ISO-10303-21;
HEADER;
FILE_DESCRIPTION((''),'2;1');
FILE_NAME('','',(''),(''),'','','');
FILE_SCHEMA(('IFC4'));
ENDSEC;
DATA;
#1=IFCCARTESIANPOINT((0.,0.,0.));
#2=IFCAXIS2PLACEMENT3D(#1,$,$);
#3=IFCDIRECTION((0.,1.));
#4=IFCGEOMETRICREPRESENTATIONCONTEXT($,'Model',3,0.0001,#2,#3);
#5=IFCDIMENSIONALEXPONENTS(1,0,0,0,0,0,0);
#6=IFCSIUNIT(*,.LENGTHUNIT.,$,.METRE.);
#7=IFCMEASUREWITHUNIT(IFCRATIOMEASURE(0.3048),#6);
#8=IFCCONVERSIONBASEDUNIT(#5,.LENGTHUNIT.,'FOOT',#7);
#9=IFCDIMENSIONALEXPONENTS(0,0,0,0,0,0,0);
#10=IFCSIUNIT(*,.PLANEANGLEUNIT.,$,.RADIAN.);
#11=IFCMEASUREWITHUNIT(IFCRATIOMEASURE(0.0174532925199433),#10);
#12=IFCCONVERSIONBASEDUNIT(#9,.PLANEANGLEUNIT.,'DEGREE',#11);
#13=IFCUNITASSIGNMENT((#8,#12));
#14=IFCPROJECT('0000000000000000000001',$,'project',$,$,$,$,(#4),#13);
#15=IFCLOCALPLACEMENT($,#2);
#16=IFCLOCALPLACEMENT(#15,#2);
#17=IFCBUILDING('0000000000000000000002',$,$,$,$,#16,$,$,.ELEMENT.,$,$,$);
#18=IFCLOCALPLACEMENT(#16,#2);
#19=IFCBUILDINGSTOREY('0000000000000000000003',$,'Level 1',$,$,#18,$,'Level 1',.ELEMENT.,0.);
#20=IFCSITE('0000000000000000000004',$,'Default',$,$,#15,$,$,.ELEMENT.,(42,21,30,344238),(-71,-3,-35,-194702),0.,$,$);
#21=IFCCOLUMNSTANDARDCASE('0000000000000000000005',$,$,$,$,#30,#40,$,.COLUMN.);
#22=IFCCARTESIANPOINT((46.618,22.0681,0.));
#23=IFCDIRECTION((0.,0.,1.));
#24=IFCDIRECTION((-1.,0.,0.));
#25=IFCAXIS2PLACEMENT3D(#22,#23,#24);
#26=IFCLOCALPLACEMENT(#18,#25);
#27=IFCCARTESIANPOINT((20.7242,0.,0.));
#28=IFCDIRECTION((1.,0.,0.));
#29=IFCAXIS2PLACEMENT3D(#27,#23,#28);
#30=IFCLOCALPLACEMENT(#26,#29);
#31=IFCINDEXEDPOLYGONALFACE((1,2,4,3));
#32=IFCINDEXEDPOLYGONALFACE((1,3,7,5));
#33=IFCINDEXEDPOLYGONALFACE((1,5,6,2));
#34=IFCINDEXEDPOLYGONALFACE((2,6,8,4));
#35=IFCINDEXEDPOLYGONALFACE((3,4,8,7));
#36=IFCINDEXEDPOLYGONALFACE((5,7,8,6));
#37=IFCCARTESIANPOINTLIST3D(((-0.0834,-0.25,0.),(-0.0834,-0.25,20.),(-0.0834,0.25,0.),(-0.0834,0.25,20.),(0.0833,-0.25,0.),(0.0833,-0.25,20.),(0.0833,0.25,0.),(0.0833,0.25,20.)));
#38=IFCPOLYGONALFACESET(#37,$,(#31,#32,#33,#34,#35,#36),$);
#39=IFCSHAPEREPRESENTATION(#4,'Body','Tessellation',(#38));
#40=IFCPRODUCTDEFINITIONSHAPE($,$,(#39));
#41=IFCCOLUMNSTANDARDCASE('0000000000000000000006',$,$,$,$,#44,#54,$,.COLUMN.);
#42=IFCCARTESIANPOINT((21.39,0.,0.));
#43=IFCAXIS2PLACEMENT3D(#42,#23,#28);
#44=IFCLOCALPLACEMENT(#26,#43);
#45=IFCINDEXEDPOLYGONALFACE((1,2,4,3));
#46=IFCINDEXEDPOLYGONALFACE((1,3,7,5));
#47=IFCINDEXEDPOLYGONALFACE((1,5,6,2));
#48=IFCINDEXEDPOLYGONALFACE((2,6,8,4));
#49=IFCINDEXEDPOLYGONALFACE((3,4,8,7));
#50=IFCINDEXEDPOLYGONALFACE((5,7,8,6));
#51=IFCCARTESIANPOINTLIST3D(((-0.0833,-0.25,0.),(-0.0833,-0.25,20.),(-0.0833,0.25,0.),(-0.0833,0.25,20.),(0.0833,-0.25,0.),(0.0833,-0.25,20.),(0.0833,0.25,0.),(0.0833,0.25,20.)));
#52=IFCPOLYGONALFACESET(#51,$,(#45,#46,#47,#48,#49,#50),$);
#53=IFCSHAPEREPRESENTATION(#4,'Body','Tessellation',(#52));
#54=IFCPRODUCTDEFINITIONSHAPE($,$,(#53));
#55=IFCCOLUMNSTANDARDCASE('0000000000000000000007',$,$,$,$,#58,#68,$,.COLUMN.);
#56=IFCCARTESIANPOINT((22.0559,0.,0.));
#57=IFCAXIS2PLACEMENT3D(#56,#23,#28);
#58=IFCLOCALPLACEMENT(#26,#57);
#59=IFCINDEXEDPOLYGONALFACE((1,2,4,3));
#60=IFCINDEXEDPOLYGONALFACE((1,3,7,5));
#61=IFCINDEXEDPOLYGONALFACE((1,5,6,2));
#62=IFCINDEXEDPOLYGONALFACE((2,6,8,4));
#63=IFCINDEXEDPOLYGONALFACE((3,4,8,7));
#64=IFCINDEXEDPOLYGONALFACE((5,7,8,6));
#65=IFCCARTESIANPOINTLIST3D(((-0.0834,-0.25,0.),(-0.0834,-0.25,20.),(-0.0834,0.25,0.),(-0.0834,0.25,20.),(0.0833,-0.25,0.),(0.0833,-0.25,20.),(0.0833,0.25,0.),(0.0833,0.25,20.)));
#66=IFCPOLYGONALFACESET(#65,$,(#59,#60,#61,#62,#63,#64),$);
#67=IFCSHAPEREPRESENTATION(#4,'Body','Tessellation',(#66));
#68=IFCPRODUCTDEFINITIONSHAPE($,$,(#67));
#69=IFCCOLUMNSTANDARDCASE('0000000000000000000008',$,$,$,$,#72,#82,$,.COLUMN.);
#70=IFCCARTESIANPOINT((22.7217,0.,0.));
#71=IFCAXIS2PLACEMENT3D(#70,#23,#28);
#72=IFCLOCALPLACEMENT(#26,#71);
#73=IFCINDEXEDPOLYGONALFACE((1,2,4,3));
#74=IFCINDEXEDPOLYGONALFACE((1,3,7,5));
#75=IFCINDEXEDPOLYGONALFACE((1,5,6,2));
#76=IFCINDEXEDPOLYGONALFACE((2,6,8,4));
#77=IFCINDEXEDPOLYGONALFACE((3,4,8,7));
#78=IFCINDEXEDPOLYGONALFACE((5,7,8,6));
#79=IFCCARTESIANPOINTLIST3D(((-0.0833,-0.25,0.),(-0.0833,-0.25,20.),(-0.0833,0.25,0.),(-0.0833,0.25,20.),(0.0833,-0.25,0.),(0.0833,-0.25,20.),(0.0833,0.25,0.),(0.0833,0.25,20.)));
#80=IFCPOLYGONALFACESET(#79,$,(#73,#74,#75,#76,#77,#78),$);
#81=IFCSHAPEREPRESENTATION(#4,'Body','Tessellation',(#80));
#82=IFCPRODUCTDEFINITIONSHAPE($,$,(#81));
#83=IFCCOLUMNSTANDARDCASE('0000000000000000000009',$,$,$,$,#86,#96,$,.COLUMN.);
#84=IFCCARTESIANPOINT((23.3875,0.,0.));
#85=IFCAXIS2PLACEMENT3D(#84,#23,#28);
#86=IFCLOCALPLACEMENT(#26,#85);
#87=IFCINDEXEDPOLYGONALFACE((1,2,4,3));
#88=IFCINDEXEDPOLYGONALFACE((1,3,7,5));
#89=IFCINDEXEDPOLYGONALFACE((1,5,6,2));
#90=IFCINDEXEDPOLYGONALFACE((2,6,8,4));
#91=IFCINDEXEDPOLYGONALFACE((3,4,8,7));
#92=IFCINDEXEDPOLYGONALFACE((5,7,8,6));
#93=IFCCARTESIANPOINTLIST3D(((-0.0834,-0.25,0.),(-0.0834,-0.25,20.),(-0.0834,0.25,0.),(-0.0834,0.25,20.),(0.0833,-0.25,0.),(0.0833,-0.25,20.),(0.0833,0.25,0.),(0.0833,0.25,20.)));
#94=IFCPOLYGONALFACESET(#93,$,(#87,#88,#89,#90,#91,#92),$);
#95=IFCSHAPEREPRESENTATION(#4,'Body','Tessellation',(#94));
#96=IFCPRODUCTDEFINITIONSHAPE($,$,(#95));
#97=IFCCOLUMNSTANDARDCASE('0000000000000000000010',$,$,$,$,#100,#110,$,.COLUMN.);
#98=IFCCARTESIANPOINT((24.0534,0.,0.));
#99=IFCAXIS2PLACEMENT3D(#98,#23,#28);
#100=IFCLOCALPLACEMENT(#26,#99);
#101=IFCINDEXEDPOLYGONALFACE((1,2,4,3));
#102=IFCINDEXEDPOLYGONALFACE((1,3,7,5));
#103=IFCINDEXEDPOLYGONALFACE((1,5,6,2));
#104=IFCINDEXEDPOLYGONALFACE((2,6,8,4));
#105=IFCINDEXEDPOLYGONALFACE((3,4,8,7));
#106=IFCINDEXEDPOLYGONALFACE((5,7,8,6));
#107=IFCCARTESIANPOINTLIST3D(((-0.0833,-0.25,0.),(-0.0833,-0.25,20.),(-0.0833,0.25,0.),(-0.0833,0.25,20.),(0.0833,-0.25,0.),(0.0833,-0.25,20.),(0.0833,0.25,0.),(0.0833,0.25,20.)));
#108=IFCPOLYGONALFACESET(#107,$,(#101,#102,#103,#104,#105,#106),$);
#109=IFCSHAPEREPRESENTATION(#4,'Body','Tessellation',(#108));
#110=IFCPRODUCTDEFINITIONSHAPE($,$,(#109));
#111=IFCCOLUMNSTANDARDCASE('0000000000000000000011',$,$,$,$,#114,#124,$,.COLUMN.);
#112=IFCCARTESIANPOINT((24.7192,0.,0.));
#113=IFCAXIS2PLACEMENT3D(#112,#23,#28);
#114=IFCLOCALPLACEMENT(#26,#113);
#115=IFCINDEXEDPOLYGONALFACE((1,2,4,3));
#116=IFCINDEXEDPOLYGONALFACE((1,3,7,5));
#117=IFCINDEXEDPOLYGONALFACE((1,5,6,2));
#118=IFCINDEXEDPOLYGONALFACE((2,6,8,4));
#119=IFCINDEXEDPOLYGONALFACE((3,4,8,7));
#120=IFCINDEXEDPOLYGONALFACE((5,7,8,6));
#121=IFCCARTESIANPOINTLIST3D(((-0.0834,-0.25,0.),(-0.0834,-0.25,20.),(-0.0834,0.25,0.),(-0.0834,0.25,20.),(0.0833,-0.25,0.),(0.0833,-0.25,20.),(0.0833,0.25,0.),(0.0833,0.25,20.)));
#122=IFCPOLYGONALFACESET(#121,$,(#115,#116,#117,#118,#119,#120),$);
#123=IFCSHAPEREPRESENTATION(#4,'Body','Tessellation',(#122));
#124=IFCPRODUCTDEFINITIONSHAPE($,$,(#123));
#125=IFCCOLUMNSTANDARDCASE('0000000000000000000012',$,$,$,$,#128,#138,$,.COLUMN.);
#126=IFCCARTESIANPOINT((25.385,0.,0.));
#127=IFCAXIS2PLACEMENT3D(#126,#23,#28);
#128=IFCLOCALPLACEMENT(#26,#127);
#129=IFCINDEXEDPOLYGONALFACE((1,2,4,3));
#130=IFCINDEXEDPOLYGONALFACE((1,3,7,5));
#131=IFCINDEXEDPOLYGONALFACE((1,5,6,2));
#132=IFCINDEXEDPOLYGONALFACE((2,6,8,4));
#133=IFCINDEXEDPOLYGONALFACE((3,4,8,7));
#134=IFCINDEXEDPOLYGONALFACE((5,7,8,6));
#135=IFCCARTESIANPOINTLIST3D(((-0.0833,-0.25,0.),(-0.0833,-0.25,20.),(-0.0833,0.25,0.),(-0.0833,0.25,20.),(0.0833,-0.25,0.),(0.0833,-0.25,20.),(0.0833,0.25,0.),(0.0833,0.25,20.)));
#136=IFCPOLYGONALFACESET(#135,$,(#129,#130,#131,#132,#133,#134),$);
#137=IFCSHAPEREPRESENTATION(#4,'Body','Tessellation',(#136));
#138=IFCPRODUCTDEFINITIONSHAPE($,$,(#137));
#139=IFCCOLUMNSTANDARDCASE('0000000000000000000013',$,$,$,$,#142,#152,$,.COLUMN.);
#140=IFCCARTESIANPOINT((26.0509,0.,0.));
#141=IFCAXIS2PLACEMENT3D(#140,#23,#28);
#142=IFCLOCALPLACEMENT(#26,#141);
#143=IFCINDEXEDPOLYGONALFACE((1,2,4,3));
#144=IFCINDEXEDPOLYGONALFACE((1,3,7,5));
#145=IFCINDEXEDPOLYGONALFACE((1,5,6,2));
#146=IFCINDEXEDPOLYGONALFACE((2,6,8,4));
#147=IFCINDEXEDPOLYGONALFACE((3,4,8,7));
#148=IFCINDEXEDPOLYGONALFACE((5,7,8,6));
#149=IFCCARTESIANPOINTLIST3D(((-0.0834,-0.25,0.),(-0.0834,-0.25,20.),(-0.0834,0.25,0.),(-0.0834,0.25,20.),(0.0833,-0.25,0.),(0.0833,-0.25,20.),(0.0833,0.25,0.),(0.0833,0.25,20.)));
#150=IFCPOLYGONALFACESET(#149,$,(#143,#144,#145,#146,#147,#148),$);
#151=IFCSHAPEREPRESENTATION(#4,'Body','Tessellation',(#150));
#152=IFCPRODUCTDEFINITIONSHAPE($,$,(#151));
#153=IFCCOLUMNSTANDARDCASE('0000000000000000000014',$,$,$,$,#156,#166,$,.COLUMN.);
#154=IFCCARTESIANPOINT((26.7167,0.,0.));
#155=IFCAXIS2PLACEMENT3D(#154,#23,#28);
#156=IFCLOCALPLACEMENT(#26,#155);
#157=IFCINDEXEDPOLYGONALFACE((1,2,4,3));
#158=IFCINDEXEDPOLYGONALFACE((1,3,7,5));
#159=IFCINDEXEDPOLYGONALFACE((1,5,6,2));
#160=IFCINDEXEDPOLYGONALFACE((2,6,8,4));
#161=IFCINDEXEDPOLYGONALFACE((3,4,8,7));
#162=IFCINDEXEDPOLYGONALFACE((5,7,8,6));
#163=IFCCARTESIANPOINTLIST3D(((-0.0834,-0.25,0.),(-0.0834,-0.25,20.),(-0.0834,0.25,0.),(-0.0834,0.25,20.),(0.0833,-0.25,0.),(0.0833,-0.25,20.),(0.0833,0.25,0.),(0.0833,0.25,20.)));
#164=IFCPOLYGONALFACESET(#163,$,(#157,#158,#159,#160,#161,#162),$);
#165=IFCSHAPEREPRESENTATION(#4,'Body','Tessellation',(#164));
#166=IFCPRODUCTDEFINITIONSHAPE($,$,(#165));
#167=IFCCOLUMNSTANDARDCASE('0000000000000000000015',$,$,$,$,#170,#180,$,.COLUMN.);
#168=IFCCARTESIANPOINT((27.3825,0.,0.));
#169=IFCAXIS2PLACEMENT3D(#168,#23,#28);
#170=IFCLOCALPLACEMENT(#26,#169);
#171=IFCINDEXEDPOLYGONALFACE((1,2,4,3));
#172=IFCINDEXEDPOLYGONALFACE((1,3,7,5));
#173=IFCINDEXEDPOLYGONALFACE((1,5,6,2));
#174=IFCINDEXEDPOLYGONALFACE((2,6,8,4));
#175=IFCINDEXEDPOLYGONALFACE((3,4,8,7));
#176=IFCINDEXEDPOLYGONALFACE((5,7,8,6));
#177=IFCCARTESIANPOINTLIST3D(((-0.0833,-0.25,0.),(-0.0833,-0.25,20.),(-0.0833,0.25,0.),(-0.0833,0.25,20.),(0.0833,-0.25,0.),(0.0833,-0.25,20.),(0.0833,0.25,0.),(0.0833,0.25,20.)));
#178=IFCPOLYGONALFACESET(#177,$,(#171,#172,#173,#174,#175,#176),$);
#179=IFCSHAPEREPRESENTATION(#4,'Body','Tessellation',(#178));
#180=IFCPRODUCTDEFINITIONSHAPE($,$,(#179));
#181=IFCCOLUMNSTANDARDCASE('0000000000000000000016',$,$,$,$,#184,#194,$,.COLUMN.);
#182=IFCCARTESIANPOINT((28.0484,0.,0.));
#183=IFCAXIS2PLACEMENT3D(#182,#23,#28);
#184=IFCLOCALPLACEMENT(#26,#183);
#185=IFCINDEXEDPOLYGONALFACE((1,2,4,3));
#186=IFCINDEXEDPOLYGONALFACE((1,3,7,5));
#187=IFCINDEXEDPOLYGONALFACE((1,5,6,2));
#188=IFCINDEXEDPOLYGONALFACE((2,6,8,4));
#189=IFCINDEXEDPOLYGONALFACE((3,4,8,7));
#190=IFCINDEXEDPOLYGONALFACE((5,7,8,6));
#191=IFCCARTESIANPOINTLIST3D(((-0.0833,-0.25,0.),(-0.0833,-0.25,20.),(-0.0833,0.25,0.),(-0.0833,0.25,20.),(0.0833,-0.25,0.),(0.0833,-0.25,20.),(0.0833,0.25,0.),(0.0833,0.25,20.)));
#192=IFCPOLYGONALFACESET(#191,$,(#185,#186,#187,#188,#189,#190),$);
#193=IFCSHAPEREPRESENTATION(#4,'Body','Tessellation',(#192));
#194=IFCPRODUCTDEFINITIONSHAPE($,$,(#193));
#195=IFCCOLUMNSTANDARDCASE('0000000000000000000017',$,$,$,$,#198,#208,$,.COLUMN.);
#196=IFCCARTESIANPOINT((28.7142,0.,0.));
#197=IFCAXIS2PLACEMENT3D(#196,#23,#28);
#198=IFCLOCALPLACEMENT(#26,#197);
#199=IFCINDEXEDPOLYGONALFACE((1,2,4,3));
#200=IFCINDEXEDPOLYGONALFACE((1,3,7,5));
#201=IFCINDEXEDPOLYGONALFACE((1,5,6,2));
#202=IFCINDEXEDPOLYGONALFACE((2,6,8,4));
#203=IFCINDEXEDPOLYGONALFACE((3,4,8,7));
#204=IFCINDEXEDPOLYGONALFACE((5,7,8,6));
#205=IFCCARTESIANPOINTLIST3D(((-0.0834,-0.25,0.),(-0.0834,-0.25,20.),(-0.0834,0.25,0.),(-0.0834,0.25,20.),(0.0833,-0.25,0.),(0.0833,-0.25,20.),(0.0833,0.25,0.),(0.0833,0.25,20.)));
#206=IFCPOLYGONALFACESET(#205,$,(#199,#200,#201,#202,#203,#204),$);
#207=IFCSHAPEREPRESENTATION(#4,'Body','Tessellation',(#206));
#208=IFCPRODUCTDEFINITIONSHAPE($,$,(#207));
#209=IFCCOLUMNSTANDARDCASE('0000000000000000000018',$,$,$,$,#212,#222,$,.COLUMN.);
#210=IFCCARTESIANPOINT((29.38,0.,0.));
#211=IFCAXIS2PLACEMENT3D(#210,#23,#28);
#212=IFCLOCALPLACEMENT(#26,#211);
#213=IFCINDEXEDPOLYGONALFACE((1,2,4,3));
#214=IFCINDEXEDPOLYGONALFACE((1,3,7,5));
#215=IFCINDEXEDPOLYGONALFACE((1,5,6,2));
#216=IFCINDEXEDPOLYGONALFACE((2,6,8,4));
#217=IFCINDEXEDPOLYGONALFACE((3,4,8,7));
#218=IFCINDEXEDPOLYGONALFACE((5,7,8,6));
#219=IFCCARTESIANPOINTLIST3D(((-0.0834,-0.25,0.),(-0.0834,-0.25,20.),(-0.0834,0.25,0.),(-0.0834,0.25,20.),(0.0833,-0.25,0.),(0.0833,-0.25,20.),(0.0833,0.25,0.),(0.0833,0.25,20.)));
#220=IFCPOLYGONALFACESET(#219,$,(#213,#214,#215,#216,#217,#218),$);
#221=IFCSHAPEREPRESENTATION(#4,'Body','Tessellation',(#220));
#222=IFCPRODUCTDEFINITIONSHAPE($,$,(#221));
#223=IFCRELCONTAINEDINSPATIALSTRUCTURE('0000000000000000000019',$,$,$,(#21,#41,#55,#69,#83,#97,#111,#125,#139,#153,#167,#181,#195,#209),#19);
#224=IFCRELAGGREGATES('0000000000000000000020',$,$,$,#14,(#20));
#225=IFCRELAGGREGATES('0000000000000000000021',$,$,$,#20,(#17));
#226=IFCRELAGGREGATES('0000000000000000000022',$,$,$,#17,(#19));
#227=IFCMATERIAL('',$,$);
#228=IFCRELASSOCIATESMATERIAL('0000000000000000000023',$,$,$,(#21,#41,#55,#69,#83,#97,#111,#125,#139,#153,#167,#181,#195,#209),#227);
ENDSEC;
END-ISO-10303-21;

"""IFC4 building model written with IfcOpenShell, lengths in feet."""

from ifc_helpers import new_model, entity, si_unit, converted_unit, direction, frame, origin, place, context, project, spatial, rectangle, extrude, material, element, save


model = new_model("IFC4")

# Units and contexts
model_context = context("Model", 3, precision=0.0001, world=origin(), true_north=direction((0.0, 1.0)))
ifc_project = project(units=[converted_unit("LENGTHUNIT", "FOOT", entity("IfcRatioMeasure", 0.3048), si_unit("LENGTHUNIT", "METRE"), dimensions=[1, 0, 0, 0, 0, 0, 0]), converted_unit("PLANEANGLEUNIT", "DEGREE", entity("IfcRatioMeasure", 0.0174532925199433), si_unit("PLANEANGLEUNIT", "RADIAN"), dimensions=[0, 0, 0, 0, 0, 0, 0])], contexts=[model_context])

# Site, building, storey
site_placement = place(None, origin())
site = spatial("IfcSite", under=ifc_project, at=site_placement, Name="Default", CompositionType="ELEMENT", RefLatitude=(42, 21, 30, 344238), RefLongitude=(-71, -3, -35, -194702), RefElevation=0.0)
building_placement = place(site_placement, origin())
building = spatial("IfcBuilding", under=site, at=building_placement, CompositionType="ELEMENT")
storey_placement = place(building_placement, origin())
storey = spatial("IfcBuildingStorey", under=building, at=storey_placement, Name="Level 1", LongName="Level 1", CompositionType="ELEMENT", Elevation=0.0)

# Columns
ifc_material = material(Name="")
placement = place(storey_placement, frame((46.618, 22.0681, 0.0), z_axis=(0.0, 0.0, 1.0), x_axis=(-1.0, 0.0, 0.0)))
for number, where, z_axis, x_axis in (
    (1, (20.7242, 0.0, 0.0), (0.0, 0.0, 1.0), (1.0, 0.0, 0.0)),
    (2, (21.39, 0.0, 0.0), (0.0, 0.0, 1.0), (1.0, 0.0, 0.0)),
    (3, (22.0559, 0.0, 0.0), (0.0, 0.0, 1.0), (1.0, 0.0, 0.0)),
    (4, (22.7217, 0.0, 0.0), (0.0, 0.0, 1.0), (1.0, 0.0, 0.0)),
    (5, (23.3875, 0.0, 0.0), (0.0, 0.0, 1.0), (1.0, 0.0, 0.0)),
    (6, (24.0534, 0.0, 0.0), (0.0, 0.0, 1.0), (1.0, 0.0, 0.0)),
    (7, (24.7192, 0.0, 0.0), (0.0, 0.0, 1.0), (1.0, 0.0, 0.0)),
    (8, (25.385, 0.0, 0.0), (0.0, 0.0, 1.0), (1.0, 0.0, 0.0)),
    (9, (26.0509, 0.0, 0.0), (0.0, 0.0, 1.0), (1.0, 0.0, 0.0)),
    (10, (26.7167, 0.0, 0.0), (0.0, 0.0, 1.0), (1.0, 0.0, 0.0)),
    (11, (27.3825, 0.0, 0.0), (0.0, 0.0, 1.0), (1.0, 0.0, 0.0)),
    (12, (28.0484, 0.0, 0.0), (0.0, 0.0, 1.0), (1.0, 0.0, 0.0)),
    (13, (28.7142, 0.0, 0.0), (0.0, 0.0, 1.0), (1.0, 0.0, 0.0)),
    (14, (29.38, 0.0, 0.0), (0.0, 0.0, 1.0), (1.0, 0.0, 0.0)),
):
    element("IfcColumnStandardCase", number, at=place(placement, frame(where, z_axis=z_axis, x_axis=x_axis)), inside=storey, material=ifc_material, PredefinedType="COLUMN", context=model_context, shape_type="SweptSolid", body=[
        extrude(rectangle(XDim=0.1667, YDim=0.5), origin(), (0.0, 0.0, 1.0), 20.0),
    ])

save(model, "model.ifc")
